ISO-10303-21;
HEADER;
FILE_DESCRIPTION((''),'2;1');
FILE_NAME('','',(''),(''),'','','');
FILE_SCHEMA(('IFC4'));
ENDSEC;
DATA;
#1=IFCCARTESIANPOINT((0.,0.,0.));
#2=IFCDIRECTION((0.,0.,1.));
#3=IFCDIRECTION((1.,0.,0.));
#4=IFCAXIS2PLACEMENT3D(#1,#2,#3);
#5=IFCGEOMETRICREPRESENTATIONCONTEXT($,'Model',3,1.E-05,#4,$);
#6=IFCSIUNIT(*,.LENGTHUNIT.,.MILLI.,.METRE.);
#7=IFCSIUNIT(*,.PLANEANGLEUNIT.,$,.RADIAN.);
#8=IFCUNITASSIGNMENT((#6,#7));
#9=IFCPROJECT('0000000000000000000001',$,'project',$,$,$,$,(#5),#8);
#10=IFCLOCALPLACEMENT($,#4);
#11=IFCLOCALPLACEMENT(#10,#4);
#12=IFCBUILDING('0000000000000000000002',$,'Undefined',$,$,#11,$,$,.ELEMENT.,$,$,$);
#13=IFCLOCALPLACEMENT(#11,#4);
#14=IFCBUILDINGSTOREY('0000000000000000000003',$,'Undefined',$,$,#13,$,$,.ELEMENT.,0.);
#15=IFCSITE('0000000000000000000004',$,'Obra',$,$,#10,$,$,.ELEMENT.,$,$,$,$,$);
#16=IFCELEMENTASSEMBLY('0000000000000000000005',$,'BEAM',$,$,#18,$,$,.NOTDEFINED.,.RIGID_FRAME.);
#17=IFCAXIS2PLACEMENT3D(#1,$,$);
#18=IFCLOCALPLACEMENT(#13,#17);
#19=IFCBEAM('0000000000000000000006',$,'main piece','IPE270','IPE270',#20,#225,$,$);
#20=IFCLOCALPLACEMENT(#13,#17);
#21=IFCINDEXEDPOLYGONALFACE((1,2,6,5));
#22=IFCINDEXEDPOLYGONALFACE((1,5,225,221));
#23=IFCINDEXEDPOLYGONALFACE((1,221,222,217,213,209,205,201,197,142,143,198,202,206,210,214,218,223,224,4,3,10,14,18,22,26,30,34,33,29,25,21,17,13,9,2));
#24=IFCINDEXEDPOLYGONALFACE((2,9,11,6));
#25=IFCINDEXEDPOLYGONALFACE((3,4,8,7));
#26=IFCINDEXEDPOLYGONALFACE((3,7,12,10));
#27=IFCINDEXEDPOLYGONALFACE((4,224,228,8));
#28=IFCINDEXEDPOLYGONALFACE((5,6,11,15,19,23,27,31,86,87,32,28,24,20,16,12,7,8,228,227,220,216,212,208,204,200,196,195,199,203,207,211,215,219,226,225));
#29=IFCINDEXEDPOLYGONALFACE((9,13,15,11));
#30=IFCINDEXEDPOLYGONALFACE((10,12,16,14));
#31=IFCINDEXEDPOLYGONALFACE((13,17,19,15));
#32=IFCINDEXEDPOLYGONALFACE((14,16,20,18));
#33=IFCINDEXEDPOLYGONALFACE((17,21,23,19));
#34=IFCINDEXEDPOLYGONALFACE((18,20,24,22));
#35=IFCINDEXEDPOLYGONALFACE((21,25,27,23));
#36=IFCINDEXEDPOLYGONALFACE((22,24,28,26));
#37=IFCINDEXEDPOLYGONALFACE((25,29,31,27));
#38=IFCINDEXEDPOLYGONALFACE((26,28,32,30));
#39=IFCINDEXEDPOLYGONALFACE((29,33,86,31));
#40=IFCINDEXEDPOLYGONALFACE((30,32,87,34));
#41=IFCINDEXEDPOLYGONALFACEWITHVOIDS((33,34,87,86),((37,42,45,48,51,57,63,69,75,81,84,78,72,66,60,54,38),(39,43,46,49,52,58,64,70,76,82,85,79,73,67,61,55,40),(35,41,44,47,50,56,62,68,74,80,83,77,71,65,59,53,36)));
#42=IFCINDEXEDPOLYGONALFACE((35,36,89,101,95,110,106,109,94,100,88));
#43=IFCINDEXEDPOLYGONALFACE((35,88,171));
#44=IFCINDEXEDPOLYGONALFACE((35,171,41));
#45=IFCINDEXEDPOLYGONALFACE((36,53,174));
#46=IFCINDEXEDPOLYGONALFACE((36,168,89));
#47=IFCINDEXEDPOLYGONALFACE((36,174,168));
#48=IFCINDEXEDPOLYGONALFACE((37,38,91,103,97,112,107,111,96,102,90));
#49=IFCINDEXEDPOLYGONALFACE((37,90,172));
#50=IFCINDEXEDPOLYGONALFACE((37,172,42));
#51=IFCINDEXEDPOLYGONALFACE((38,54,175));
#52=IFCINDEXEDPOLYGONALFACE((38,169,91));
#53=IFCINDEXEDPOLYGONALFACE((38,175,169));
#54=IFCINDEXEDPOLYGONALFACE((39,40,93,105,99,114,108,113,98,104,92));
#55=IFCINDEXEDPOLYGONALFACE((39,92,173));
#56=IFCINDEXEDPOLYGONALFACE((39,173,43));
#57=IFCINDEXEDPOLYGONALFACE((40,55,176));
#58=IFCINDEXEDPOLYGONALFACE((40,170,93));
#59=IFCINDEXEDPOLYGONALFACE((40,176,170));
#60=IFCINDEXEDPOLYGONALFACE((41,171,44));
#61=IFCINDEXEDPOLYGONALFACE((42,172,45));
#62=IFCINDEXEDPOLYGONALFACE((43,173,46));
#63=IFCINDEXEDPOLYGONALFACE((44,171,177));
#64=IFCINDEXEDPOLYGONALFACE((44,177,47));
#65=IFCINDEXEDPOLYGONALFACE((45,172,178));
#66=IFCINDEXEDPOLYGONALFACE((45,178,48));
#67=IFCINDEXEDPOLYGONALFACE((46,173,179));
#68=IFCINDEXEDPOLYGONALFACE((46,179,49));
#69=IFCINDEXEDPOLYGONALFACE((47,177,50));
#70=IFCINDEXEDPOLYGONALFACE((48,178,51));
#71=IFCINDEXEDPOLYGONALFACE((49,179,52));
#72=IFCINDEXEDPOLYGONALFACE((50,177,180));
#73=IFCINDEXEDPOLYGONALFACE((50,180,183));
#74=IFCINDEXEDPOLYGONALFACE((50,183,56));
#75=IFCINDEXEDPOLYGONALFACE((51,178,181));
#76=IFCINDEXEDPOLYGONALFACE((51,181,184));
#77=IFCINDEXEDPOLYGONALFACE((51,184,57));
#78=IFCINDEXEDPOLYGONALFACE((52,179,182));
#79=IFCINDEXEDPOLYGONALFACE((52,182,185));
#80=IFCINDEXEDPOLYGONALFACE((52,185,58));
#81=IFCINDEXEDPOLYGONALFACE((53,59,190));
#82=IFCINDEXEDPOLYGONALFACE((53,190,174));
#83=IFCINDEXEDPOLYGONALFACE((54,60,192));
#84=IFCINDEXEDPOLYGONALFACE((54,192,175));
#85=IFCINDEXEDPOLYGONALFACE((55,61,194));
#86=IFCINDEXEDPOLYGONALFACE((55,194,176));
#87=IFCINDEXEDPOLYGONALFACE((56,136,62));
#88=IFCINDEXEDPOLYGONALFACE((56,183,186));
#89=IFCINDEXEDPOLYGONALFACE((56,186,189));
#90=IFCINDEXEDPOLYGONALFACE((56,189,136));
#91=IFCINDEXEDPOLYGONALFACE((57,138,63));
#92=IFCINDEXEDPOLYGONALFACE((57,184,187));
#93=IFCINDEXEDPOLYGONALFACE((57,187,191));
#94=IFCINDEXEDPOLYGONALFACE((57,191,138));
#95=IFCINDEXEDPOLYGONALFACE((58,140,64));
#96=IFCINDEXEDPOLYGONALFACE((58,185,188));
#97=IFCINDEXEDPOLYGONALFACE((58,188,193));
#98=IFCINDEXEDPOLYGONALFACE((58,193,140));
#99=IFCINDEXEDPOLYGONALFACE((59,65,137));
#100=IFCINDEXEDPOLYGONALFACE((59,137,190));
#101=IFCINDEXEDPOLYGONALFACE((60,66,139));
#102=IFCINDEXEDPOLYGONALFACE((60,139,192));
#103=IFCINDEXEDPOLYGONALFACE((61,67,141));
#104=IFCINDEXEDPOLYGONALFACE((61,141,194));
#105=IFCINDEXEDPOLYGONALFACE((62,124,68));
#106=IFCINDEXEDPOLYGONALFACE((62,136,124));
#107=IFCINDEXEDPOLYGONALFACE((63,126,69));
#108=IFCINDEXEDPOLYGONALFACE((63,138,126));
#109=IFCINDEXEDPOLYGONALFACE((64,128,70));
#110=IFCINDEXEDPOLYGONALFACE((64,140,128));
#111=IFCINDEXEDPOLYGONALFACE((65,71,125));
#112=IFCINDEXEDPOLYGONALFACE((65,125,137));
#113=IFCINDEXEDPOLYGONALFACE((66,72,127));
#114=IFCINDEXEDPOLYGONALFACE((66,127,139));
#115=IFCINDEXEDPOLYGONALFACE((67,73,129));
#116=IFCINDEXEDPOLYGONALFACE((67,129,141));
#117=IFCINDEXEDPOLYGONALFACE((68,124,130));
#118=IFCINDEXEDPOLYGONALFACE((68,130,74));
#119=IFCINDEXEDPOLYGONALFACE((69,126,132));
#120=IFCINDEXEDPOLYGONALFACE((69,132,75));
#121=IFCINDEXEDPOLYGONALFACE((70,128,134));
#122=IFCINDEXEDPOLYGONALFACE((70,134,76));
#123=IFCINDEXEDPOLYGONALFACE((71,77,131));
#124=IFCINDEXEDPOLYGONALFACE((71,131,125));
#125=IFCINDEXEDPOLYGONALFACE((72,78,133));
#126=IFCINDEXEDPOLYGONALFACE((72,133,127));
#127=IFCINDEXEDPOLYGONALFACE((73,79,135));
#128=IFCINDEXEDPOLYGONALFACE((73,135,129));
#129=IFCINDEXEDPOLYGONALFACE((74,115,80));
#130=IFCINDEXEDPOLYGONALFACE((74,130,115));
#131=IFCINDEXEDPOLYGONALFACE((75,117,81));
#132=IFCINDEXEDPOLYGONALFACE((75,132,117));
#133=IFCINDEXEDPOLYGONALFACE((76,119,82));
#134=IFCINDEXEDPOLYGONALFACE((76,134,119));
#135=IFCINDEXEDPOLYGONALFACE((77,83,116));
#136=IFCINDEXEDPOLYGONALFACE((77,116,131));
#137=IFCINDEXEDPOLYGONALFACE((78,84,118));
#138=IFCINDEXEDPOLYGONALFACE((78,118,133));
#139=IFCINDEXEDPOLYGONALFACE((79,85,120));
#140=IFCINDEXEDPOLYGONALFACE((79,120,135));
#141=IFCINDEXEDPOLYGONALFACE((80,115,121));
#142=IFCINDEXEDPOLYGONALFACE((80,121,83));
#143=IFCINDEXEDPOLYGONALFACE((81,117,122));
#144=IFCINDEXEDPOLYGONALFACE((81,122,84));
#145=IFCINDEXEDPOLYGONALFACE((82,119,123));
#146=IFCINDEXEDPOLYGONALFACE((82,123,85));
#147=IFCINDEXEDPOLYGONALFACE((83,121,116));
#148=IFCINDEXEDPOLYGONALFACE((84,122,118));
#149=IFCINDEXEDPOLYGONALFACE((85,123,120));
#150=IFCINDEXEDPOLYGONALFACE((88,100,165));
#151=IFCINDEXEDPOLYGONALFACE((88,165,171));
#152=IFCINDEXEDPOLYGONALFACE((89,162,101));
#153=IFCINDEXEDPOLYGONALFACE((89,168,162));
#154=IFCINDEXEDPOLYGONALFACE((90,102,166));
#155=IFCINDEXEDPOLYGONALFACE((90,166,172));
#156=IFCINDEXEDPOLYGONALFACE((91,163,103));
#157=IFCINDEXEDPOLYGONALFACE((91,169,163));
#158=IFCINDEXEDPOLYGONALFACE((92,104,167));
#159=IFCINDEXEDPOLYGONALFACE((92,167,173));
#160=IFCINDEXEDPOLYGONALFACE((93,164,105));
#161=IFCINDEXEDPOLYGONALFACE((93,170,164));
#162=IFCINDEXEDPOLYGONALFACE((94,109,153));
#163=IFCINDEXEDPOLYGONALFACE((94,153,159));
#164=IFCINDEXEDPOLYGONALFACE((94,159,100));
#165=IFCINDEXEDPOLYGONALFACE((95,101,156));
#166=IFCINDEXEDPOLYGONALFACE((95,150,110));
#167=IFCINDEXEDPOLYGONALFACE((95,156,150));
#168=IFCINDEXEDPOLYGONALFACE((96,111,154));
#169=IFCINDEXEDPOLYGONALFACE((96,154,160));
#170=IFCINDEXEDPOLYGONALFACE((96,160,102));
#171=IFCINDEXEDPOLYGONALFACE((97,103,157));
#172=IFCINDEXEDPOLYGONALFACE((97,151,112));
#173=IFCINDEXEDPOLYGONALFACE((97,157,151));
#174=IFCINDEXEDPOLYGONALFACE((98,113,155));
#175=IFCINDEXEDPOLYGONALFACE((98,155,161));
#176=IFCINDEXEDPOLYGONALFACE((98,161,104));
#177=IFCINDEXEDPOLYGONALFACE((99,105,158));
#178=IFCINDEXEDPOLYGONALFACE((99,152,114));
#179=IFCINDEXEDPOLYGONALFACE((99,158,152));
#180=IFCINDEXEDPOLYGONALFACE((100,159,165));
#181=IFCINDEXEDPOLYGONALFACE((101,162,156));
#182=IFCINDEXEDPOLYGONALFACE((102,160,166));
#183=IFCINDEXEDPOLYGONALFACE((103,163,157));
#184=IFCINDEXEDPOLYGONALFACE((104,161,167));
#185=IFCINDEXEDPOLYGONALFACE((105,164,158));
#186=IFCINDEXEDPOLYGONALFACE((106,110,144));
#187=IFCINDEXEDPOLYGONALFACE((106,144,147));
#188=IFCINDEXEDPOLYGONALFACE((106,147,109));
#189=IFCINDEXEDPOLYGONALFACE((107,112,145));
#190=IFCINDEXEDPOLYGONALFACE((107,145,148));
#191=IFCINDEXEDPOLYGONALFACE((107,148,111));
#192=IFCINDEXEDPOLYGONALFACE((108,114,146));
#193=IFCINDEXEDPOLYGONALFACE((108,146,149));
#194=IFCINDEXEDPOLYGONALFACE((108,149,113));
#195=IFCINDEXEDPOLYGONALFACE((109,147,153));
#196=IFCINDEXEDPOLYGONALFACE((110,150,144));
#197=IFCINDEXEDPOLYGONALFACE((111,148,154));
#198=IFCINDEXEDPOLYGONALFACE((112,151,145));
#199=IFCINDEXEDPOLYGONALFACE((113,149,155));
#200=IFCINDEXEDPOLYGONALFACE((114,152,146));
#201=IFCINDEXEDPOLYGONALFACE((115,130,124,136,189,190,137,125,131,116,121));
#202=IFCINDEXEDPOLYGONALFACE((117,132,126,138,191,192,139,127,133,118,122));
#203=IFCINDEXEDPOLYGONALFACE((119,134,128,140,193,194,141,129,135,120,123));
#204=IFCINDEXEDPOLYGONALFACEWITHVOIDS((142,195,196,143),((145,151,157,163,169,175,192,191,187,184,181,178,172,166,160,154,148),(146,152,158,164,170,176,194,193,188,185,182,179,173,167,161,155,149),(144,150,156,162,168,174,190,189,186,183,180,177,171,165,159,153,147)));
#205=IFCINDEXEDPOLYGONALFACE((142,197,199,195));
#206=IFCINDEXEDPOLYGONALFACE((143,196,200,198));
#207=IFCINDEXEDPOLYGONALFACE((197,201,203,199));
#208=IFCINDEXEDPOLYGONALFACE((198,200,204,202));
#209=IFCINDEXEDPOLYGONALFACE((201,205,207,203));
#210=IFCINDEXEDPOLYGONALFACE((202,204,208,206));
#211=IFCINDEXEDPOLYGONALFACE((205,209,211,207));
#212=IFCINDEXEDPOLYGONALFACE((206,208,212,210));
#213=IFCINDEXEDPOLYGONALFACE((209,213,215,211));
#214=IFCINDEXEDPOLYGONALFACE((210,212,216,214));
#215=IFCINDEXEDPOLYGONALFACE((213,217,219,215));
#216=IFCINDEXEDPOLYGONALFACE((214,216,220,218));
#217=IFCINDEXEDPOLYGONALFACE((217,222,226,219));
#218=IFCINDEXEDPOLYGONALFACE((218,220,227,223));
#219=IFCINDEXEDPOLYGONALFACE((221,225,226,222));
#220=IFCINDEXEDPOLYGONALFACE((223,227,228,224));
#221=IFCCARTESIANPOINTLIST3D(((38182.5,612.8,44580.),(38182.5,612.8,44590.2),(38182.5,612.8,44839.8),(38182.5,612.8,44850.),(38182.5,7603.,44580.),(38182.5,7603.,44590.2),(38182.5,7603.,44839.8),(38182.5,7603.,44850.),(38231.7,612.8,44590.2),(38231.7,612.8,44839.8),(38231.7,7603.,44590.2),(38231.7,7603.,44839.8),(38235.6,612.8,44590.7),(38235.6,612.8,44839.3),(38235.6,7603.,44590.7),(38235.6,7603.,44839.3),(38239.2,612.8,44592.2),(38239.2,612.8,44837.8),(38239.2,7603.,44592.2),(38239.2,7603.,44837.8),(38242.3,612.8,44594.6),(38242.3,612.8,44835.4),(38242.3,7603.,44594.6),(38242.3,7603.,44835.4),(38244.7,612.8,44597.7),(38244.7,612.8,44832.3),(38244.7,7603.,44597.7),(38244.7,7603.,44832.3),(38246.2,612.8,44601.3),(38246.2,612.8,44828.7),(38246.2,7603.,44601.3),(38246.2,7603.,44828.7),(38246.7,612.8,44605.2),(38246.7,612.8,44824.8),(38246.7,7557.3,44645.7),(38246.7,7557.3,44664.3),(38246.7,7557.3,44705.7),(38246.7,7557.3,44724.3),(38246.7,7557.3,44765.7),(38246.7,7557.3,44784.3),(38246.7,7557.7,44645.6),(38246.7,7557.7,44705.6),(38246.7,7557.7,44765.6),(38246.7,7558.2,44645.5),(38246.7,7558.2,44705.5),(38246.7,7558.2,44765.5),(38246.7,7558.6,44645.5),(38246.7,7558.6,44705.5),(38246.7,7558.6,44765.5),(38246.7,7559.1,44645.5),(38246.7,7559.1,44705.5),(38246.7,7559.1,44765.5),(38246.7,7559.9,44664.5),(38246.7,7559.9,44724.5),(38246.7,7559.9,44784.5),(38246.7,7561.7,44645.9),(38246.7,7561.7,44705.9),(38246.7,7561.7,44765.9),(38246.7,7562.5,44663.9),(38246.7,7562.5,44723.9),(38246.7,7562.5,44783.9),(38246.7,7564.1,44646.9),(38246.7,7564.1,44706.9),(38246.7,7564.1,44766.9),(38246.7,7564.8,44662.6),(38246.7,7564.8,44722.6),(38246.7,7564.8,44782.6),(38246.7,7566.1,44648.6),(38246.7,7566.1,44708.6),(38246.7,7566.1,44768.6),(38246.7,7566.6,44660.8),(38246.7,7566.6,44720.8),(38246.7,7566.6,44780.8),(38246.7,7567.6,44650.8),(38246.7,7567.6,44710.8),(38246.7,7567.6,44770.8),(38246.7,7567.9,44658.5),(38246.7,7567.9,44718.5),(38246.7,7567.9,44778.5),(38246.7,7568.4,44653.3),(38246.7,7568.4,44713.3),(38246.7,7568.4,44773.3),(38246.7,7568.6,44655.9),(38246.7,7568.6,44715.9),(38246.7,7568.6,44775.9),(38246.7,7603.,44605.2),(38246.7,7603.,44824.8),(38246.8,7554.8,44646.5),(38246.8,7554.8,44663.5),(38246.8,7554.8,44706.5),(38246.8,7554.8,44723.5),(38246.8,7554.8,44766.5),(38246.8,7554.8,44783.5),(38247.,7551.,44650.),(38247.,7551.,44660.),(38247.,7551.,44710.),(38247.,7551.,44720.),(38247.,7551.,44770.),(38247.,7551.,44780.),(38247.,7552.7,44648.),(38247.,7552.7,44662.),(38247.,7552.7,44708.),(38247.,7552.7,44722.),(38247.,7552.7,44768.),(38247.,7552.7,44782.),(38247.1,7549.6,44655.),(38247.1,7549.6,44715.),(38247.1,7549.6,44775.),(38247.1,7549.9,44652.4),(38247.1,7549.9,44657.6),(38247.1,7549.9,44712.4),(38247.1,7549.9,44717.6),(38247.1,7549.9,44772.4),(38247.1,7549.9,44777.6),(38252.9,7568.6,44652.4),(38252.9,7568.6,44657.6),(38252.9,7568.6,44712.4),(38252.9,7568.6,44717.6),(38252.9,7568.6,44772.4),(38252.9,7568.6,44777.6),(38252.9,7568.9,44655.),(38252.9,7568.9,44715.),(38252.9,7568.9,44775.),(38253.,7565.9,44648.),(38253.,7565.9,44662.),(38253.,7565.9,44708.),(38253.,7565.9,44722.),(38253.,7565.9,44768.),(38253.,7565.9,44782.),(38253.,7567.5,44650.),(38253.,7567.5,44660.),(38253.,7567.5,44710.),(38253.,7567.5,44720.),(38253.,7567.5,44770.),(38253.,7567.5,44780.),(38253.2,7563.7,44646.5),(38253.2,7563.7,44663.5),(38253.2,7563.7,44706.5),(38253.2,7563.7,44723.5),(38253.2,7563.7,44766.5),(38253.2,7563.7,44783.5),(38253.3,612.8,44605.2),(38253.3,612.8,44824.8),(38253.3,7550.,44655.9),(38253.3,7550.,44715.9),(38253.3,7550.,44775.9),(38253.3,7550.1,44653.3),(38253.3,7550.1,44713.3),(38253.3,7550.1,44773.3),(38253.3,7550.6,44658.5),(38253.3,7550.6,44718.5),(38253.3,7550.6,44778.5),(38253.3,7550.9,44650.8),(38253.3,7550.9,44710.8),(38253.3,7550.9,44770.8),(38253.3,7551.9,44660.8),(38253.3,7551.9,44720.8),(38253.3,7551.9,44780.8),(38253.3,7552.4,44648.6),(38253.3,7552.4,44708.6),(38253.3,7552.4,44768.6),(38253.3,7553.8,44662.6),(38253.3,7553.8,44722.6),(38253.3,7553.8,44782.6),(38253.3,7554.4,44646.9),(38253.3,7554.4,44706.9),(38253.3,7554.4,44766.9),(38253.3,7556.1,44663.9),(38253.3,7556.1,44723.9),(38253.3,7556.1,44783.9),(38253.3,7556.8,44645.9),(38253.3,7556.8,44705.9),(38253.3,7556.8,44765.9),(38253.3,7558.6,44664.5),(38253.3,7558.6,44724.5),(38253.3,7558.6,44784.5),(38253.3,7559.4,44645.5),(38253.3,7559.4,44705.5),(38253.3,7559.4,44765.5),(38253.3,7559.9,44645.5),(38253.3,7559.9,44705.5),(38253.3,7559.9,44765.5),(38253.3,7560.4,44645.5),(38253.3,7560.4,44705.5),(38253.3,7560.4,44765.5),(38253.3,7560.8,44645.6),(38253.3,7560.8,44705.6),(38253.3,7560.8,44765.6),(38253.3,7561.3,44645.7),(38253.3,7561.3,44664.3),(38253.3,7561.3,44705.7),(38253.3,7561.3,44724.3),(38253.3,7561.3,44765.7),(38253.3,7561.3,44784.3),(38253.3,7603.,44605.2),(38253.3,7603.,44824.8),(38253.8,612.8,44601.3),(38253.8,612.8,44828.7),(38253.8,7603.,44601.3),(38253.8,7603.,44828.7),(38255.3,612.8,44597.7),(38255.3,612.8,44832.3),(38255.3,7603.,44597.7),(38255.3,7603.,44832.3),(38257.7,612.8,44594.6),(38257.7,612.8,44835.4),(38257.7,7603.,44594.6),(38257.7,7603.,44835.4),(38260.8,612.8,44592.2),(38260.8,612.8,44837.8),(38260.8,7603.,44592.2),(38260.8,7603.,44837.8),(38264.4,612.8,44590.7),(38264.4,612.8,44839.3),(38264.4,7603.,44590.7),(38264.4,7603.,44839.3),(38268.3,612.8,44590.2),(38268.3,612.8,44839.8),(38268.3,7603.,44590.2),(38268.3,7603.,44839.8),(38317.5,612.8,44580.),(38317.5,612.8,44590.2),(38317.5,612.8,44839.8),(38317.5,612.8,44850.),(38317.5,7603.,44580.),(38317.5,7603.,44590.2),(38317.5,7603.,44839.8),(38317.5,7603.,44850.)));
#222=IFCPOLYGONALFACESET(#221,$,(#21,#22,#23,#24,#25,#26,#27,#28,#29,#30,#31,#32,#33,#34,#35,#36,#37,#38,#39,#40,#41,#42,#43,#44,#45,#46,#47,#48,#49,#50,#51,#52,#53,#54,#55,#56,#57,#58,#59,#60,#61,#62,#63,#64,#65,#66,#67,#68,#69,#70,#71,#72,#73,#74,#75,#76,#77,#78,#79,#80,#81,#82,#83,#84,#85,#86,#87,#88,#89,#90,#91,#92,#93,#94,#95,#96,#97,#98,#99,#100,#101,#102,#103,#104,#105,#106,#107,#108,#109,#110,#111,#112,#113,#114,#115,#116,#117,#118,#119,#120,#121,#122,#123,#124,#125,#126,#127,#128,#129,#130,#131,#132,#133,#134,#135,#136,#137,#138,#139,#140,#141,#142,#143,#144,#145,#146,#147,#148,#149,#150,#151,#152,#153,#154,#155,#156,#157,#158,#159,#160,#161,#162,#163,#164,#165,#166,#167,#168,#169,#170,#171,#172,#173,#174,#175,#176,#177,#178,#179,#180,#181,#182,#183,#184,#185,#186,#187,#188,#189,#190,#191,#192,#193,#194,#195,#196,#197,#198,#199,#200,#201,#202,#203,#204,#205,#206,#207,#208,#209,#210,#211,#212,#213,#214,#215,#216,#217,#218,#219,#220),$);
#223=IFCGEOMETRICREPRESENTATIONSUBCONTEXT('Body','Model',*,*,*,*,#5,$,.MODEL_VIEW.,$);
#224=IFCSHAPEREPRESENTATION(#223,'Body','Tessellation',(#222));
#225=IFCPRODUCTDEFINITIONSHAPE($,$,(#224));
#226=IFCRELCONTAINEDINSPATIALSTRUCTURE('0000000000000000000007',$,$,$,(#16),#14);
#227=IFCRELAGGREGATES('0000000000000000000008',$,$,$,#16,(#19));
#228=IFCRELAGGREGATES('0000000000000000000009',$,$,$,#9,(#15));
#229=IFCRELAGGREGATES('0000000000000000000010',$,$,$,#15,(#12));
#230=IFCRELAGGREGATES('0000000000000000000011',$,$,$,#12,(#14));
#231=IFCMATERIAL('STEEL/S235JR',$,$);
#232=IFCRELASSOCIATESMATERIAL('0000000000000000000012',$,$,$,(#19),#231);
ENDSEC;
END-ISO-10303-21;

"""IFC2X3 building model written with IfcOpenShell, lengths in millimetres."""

from ifc_helpers import new_model, si_unit, frame, origin_with_axes, origin_2d_with_axis, place, context, subcontext, project, spatial, circle, i_section, extrude, clip, halfspace, source, transform, mapped, material, element, aggregate, save


model = new_model("IFC2X3")

# Units and contexts
model_context = context("Model", 3, precision=1e-05, world=origin_with_axes())
body_context = subcontext(model_context, "Body", "Model", "MODEL_VIEW")
ifc_project = project(units=[si_unit("LENGTHUNIT", "METRE", prefix="MILLI"), si_unit("PLANEANGLEUNIT", "RADIAN")], contexts=[model_context])

# Site, building, storey
site_placement = place(None, origin_with_axes())
site = spatial("IfcSite", under=ifc_project, at=site_placement, Name="Obra", CompositionType="ELEMENT")
building_placement = place(site_placement, origin_with_axes())
building = spatial("IfcBuilding", under=site, at=building_placement, Name="Undefined", CompositionType="ELEMENT")
storey_placement = place(building_placement, origin_with_axes())
storey = spatial("IfcBuildingStorey", under=building, at=storey_placement, Name="Undefined", CompositionType="ELEMENT", Elevation=0.0)

# Shared definitions
ifc_material_1 = material(Name="STEEL/S235JR")

# Element assembly, beam, opening
assembly_1_placement = place(storey_placement, origin_with_axes())
assembly_1 = element("IfcElementAssembly", 1, at=assembly_1_placement, inside=storey, Name="BEAM", AssemblyPlace="NOTDEFINED", PredefinedType="RIGID_FRAME")
beam_1_placement = place(assembly_1_placement, frame((38250.0, 7603.0, 44715.0), z_axis=(0.0, 0.0, 1.0), x_axis=(0.0, -1.0, 0.0)))
beam_1 = element("IfcBeam", 2, at=beam_1_placement, material=ifc_material_1, Name="main piece", Description="IPE270", ObjectType="IPE270", context=body_context, shape_type="Clipping", body=[
    clip(extrude(i_section(OverallWidth=135.0, OverallDepth=270.0, WebThickness=6.6, FlangeThickness=10.2, FilletRadius=15.0, at=origin_2d_with_axis()), frame((6990.2, 0.0, 0.0), z_axis=(-1.0, 0.0, 0.0), x_axis=(0.0, -1.0, 0.0)), (0.0, 0.0, 1.0), 6990.2), halfspace(frame((-10.8, 88.1, -120.0), z_axis=(-0.998477, -0.055171, 0.0), x_axis=(0.0, 0.0, 1.0)), False)),
])
shared_shape_1 = source(origin_with_axes(), body_context, "Body", "SweptSolid", [
    extrude(circle(Radius=9.5, at=origin_2d_with_axis()), frame((0.0, -34.3, 0.0), z_axis=(0.0, 1.0, 0.0), x_axis=(1.0, 0.0, 0.0)), (0.0, 0.0, 1.0), 6.8),
])
opening_1_placement = place(assembly_1_placement, frame((38278.1, 7610.9, 44835.0), z_axis=(0.055152, -0.998478, 0.0), x_axis=(0.0, 0.0, -1.0)))
element("IfcOpeningElement", 3, at=opening_1_placement, cuts=beam_1, ObjectType="Opening", context=body_context, shape_type="MappedRepresentation", body=[
    mapped(shared_shape_1, transform((60.0, 0.0, 50.0))),
    mapped(shared_shape_1, transform((120.0, 0.0, 50.0))),
    mapped(shared_shape_1, transform((180.0, 0.0, 50.0))),
])
aggregate(assembly_1, [beam_1])

save(model, "model.ifc")
